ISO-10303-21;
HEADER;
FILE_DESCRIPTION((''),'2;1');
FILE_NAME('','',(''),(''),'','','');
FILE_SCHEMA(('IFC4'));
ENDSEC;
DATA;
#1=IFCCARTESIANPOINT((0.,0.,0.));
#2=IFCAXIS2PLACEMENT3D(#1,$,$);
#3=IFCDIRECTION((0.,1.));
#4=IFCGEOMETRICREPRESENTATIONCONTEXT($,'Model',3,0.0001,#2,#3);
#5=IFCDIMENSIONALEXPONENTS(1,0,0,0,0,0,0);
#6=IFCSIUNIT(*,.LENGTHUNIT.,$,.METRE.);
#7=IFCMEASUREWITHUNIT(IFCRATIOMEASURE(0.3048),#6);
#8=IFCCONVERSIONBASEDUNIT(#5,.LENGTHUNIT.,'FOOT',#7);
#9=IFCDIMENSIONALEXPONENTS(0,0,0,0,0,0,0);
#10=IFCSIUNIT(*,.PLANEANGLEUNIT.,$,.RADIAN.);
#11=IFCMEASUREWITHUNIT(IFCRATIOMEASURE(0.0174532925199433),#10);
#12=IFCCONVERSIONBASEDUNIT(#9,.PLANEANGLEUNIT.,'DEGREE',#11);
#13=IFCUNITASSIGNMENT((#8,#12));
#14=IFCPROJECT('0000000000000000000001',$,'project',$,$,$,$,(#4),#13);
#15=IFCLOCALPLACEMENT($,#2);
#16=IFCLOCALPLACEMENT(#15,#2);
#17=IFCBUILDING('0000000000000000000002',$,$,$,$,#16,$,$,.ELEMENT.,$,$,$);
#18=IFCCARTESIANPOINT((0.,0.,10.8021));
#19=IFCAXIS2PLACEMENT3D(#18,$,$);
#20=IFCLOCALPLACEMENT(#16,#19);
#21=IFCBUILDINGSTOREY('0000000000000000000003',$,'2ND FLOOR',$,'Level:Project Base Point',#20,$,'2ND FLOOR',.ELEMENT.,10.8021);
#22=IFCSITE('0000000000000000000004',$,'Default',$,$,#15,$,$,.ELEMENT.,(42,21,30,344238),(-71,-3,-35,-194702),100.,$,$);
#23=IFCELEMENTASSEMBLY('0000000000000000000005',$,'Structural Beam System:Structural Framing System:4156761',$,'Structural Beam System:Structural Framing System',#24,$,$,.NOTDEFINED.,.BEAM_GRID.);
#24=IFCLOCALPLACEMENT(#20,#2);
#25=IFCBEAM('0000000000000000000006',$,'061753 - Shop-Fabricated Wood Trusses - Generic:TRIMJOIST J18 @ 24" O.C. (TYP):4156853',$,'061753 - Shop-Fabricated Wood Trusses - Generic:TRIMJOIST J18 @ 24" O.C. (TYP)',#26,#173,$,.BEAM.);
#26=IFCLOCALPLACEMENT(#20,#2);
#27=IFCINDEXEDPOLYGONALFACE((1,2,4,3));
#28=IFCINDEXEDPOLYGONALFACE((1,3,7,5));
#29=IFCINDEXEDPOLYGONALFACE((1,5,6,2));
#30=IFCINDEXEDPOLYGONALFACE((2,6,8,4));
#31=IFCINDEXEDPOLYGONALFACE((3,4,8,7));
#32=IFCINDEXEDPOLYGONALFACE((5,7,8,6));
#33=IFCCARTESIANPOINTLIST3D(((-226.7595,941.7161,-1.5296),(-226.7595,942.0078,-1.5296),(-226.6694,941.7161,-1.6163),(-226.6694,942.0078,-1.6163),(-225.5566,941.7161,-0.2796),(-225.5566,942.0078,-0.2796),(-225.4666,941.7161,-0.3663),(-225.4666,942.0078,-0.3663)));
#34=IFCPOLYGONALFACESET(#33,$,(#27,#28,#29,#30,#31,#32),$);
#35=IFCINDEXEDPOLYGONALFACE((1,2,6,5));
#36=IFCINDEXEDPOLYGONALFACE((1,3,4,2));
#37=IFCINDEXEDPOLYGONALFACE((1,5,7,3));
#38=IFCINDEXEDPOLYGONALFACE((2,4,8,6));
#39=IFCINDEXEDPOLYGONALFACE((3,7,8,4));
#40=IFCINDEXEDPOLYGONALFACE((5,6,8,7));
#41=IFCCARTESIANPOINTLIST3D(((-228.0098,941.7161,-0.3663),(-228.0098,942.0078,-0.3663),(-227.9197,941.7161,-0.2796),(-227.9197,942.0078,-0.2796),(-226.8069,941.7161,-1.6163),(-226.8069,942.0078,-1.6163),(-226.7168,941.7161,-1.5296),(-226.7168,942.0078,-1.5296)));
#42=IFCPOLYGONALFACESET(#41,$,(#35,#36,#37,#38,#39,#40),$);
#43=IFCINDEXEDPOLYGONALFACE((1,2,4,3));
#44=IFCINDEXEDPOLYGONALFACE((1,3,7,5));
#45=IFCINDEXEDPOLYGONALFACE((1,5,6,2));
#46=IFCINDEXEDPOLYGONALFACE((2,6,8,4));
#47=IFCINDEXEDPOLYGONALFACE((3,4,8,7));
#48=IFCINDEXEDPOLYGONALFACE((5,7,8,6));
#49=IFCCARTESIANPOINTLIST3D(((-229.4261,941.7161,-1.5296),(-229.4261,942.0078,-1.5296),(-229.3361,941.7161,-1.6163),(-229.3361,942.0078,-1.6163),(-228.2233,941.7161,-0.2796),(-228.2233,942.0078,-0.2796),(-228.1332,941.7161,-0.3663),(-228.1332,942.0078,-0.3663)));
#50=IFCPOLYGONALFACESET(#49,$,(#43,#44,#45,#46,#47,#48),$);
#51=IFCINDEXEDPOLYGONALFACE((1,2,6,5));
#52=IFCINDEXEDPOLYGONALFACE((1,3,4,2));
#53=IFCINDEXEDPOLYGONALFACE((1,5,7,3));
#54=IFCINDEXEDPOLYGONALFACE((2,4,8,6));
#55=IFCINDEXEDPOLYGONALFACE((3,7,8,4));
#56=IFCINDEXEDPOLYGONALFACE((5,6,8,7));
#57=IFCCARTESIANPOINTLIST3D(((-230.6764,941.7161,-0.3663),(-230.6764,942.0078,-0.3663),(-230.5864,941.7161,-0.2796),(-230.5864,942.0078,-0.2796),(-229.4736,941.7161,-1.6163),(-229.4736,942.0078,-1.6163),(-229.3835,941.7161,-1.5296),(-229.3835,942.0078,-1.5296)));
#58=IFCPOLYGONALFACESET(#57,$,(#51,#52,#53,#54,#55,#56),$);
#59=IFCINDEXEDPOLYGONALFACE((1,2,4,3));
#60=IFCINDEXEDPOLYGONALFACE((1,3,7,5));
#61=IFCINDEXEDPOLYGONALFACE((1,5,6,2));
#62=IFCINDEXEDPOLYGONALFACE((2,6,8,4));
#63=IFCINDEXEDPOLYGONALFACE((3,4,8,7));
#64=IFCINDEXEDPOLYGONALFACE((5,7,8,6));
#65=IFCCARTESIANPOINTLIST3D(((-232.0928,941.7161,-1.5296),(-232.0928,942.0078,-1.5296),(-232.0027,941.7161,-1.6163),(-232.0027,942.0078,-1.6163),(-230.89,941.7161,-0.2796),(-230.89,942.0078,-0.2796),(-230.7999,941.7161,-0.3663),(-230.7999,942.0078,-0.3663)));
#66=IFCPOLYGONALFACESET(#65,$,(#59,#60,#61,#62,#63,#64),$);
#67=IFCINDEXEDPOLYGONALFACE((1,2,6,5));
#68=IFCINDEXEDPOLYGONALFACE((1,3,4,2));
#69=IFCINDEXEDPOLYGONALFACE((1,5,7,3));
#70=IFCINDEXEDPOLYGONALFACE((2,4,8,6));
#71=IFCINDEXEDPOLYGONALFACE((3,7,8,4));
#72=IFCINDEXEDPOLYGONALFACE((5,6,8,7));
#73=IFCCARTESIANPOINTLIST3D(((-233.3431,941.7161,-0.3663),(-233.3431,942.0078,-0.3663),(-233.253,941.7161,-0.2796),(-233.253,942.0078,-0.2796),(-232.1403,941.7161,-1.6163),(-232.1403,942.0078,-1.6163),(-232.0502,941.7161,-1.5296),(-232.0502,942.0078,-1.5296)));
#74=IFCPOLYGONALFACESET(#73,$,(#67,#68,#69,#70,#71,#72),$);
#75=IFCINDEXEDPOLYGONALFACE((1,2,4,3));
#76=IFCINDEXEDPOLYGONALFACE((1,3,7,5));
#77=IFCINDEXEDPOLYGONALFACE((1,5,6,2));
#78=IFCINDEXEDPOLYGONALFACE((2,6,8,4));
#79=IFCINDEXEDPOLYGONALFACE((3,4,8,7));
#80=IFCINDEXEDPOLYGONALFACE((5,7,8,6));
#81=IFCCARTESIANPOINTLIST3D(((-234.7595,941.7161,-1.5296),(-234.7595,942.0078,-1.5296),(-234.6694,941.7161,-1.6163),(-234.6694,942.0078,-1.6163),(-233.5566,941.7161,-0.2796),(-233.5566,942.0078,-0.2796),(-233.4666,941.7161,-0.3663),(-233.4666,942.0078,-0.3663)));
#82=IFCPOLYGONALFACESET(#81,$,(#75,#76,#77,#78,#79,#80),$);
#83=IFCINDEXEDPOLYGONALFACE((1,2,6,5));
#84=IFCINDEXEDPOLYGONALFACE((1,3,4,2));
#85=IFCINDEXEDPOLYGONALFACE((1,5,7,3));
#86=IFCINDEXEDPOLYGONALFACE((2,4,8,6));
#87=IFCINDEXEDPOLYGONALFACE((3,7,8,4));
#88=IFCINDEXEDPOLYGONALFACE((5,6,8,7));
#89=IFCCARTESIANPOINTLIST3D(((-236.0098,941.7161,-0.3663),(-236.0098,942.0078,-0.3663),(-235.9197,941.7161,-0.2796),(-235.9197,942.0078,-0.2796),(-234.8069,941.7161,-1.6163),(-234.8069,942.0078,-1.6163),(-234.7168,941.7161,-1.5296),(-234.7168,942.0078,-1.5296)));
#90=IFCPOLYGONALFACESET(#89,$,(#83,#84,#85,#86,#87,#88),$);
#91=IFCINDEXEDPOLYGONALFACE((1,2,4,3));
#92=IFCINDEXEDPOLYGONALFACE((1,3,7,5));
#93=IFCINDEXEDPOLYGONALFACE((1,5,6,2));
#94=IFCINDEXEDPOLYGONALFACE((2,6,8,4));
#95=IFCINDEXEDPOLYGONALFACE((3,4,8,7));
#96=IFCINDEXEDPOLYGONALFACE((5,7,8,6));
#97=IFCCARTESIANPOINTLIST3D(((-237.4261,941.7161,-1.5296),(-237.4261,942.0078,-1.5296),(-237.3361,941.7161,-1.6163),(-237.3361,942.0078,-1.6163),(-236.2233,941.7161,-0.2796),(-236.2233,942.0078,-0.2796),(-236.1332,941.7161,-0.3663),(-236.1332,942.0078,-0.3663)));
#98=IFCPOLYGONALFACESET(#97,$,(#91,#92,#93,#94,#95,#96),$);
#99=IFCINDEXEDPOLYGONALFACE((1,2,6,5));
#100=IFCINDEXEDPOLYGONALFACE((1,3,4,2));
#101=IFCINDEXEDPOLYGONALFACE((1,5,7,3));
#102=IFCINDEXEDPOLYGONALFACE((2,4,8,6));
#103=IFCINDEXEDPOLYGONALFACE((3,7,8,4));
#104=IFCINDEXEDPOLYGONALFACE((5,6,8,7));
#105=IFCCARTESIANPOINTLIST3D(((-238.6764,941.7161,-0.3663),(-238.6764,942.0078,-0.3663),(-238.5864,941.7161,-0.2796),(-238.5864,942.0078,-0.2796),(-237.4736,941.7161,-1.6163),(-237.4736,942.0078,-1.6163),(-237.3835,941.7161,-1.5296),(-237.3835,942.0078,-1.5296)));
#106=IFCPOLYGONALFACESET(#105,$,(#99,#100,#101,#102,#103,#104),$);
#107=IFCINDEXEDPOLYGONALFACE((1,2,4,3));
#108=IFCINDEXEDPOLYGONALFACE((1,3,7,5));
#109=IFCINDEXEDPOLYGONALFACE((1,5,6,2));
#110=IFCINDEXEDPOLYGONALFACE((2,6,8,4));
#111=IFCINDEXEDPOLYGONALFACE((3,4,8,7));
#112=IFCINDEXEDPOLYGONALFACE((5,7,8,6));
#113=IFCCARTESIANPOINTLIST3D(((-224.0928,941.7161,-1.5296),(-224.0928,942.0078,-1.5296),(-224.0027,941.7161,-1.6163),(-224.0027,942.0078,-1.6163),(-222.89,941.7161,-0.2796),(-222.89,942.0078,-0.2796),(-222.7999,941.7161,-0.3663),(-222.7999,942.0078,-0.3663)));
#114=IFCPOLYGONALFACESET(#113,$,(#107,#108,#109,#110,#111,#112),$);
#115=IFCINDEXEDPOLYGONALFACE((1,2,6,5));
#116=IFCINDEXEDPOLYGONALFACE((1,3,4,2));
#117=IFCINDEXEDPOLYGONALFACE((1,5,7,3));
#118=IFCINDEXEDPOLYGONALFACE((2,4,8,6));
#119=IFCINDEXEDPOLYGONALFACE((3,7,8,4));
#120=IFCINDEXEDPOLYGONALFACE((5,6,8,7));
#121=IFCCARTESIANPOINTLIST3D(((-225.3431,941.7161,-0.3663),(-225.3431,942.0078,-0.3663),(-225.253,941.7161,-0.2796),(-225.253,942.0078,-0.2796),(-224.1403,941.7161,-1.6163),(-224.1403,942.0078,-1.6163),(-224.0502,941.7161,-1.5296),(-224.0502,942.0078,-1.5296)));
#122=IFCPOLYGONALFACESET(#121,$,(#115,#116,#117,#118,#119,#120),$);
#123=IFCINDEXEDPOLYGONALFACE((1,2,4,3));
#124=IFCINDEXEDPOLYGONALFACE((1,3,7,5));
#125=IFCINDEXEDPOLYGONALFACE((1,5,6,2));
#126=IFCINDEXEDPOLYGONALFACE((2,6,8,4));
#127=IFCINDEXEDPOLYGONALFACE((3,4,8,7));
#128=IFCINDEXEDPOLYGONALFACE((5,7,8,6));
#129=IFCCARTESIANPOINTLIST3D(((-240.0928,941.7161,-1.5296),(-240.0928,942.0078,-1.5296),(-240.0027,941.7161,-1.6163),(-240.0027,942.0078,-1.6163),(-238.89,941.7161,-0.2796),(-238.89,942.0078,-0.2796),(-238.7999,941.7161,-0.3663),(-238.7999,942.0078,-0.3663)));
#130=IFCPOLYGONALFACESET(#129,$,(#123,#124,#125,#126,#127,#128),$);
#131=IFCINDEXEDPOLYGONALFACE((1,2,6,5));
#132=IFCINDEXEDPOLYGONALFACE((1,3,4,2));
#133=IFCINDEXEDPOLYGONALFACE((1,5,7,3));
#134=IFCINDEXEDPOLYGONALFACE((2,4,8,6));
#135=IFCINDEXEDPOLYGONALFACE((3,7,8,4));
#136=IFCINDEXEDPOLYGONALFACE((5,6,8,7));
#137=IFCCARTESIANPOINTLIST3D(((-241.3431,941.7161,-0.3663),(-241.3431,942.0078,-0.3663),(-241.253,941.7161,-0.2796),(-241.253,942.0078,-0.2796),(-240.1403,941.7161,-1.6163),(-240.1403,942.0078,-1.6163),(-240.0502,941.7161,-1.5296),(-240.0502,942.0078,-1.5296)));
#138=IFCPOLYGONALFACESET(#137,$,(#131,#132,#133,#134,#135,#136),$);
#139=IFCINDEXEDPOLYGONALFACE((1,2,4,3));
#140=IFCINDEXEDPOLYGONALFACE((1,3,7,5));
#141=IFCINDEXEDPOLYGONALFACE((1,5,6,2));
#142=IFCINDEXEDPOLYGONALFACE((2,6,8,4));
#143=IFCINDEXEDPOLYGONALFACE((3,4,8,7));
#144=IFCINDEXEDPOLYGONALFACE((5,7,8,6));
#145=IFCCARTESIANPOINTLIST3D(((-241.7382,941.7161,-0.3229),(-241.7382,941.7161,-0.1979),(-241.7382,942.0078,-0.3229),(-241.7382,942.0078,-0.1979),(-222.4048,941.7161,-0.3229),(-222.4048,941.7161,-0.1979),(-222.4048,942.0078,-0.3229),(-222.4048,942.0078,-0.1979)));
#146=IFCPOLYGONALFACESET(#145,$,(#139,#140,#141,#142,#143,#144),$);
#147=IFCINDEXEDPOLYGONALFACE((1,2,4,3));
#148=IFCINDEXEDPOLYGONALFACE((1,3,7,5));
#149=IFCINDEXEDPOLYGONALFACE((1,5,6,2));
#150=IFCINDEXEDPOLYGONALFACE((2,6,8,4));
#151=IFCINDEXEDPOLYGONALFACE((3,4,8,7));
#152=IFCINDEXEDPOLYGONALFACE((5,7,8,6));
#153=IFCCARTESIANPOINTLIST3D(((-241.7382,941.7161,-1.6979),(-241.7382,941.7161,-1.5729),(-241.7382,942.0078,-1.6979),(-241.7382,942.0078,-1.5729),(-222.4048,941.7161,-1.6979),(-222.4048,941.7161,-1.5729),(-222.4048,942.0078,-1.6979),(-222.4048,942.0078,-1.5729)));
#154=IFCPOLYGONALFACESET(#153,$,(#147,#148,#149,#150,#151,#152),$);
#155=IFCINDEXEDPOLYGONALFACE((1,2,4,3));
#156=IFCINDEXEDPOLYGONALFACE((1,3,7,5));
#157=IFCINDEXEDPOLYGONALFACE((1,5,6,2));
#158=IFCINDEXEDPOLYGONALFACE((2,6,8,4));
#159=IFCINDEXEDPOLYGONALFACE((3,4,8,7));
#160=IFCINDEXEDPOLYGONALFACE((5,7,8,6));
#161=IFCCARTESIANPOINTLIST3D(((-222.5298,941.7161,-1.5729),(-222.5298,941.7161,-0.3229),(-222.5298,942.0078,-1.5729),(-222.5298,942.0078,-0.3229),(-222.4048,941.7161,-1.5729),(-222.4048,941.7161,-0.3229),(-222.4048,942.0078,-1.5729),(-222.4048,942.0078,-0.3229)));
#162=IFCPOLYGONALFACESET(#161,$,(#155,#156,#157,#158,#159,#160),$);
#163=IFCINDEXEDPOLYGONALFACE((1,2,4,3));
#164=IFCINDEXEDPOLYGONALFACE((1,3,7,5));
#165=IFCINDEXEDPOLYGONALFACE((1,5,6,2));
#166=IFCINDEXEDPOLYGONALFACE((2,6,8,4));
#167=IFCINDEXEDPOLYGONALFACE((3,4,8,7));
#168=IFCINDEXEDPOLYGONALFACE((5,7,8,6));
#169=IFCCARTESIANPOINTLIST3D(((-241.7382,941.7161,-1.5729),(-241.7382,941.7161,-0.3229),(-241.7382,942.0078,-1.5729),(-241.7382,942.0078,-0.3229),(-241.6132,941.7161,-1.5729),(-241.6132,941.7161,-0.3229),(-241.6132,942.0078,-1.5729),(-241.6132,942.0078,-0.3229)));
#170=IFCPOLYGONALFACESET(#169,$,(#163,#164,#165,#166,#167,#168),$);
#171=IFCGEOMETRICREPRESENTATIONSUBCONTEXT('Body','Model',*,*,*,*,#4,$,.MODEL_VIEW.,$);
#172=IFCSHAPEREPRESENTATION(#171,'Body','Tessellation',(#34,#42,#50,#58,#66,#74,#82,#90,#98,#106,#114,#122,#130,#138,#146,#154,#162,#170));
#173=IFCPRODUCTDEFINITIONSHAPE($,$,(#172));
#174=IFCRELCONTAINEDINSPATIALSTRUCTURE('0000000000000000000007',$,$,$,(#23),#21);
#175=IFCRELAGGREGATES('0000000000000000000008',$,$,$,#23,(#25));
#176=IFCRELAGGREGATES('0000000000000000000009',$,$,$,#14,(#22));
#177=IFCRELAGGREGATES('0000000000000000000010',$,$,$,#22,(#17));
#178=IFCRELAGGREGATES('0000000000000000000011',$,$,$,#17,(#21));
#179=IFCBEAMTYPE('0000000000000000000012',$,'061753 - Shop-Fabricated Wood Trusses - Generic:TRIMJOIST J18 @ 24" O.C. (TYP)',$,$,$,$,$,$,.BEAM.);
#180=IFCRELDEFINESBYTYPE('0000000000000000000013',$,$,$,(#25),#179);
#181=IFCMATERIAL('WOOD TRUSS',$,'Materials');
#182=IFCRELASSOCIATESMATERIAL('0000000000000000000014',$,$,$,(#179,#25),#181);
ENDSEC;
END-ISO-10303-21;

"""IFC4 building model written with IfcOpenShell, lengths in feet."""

from ifc_helpers import new_model, entity, si_unit, converted_unit, direction, frame, frame_2d, origin, origin_2d_with_axis, place, context, subcontext, project, spatial, rectangle, extrude, source, transform, mapped, material, material_profile, profile_set, profile_usage, type_object, type_shapes, element, aggregate, save


model = new_model("IFC4")

# Units and contexts
model_context = context("Model", 3, precision=0.0001, world=origin(), true_north=direction((0.0, 1.0)))
body_context = subcontext(model_context, "Body", "Model", "MODEL_VIEW")
ifc_project = project(units=[converted_unit("LENGTHUNIT", "FOOT", entity("IfcRatioMeasure", 0.3048), si_unit("LENGTHUNIT", "METRE"), dimensions=[1, 0, 0, 0, 0, 0, 0]), converted_unit("PLANEANGLEUNIT", "DEGREE", entity("IfcRatioMeasure", 0.0174532925199433), si_unit("PLANEANGLEUNIT", "RADIAN"), dimensions=[0, 0, 0, 0, 0, 0, 0])], contexts=[model_context])

# Site, building, storey
site_placement = place(None, origin())
site = spatial("IfcSite", under=ifc_project, at=site_placement, Name="Default", CompositionType="ELEMENT", RefLatitude=(42, 21, 30, 344238), RefLongitude=(-71, -3, -35, -194702), RefElevation=100.0)
building_placement = place(site_placement, origin())
building = spatial("IfcBuilding", under=site, at=building_placement, CompositionType="ELEMENT")
storey_placement = place(building_placement, frame((0.0, 0.0, 10.8021)))
storey = spatial("IfcBuildingStorey", under=building, at=storey_placement, Name="2ND FLOOR", ObjectType="Level:Project Base Point", LongName="2ND FLOOR", CompositionType="ELEMENT", Elevation=10.8021)

# Element assembly, beam
assembly_1_placement = place(storey_placement, origin())
assembly_1 = element("IfcElementAssembly", 1, at=assembly_1_placement, inside=storey, Name="Structural Beam System:Structural Framing System:4156761", ObjectType="Structural Beam System:Structural Framing System", AssemblyPlace="NOTDEFINED", PredefinedType="BEAM_GRID")
ifc_material_1 = material(Name="WOOD TRUSS", Category="Materials")
ifc_material_profile_1 = material_profile(ifc_material_1, rectangle(XDim=1.7347, YDim=0.125, at=frame_2d((0.0, 0.0), x_axis=(1.0, 0.0))), Name="TRIMJOIST J18 @ 24\" O.C. (TYP)")
ifc_material_profile_2 = material_profile(ifc_material_1, rectangle(XDim=1.7347, YDim=0.125, at=frame_2d((0.0, 0.0), x_axis=(1.0, 0.0))), Name="TRIMJOIST J18 @ 24\" O.C. (TYP)")
ifc_material_profile_3 = material_profile(ifc_material_1, rectangle(XDim=1.7347, YDim=0.125, at=frame_2d((0.0, 0.0), x_axis=(1.0, 0.0))), Name="TRIMJOIST J18 @ 24\" O.C. (TYP)")
ifc_material_profile_4 = material_profile(ifc_material_1, rectangle(XDim=1.7347, YDim=0.125, at=frame_2d((0.0, 0.0), x_axis=(1.0, 0.0))), Name="TRIMJOIST J18 @ 24\" O.C. (TYP)")
ifc_material_profile_5 = material_profile(ifc_material_1, rectangle(XDim=1.7347, YDim=0.125, at=frame_2d((0.0, 0.0), x_axis=(1.0, 0.0))), Name="TRIMJOIST J18 @ 24\" O.C. (TYP)")
ifc_material_profile_6 = material_profile(ifc_material_1, rectangle(XDim=1.7347, YDim=0.125, at=frame_2d((0.0, 0.0), x_axis=(1.0, 0.0))), Name="TRIMJOIST J18 @ 24\" O.C. (TYP)")
ifc_material_profile_7 = material_profile(ifc_material_1, rectangle(XDim=1.7347, YDim=0.125, at=frame_2d((0.0, 0.0), x_axis=(1.0, 0.0))), Name="TRIMJOIST J18 @ 24\" O.C. (TYP)")
ifc_material_profile_8 = material_profile(ifc_material_1, rectangle(XDim=1.7347, YDim=0.125, at=frame_2d((0.0, 0.0), x_axis=(1.0, 0.0))), Name="TRIMJOIST J18 @ 24\" O.C. (TYP)")
ifc_material_profile_9 = material_profile(ifc_material_1, rectangle(XDim=1.7347, YDim=0.125, at=frame_2d((0.0, 0.0), x_axis=(1.0, 0.0))), Name="TRIMJOIST J18 @ 24\" O.C. (TYP)")
ifc_material_profile_10 = material_profile(ifc_material_1, rectangle(XDim=1.7347, YDim=0.125, at=origin_2d_with_axis()), Name="TRIMJOIST J18 @ 24\" O.C. (TYP)")
ifc_material_profile_11 = material_profile(ifc_material_1, rectangle(XDim=0.125, YDim=0.2917, at=origin_2d_with_axis()), Name="TRIMJOIST J18 @ 24\" O.C. (TYP)")
ifc_material_profile_12 = material_profile(ifc_material_1, rectangle(XDim=0.125, YDim=0.2917, at=origin_2d_with_axis()), Name="TRIMJOIST J18 @ 24\" O.C. (TYP)")
ifc_material_profile_13 = material_profile(ifc_material_1, rectangle(XDim=1.25, YDim=0.2917, at=origin_2d_with_axis()), Name="TRIMJOIST J18 @ 24\" O.C. (TYP)")
ifc_material_profile_14 = material_profile(ifc_material_1, rectangle(XDim=1.25, YDim=0.2917, at=origin_2d_with_axis()), Name="TRIMJOIST J18 @ 24\" O.C. (TYP)")
ifc_profile_set_1 = profile_set([ifc_material_profile_1, ifc_material_profile_2, ifc_material_profile_3, ifc_material_profile_4, ifc_material_profile_5, ifc_material_profile_6, ifc_material_profile_7, ifc_material_profile_8, ifc_material_profile_9, ifc_material_profile_10, ifc_material_profile_11, ifc_material_profile_12, ifc_material_profile_13, ifc_material_profile_14], Name="TRIMJOIST J18 @ 24\" O.C. (TYP)")
beam_type_1 = type_object("IfcBeamType", Name="061753 - Shop-Fabricated Wood Trusses - Generic:TRIMJOIST J18 @ 24\" O.C. (TYP)", PredefinedType="BEAM", material=ifc_profile_set_1)
shared_shape_1 = source(origin(), body_context, "Body", "SweptSolid", [
    extrude(rectangle(XDim=1.7347, YDim=0.125, at=frame_2d((0.0, 0.0), x_axis=(1.0, 0.0))), frame((5.9585, -0.1458, 0.0), z_axis=(0.0, 1.0, 0.0), x_axis=(0.693383, 0.0, 0.720569)), (0.0, 0.0, 1.0), 0.2917),
    extrude(rectangle(XDim=1.7347, YDim=0.125, at=origin_2d_with_axis()), frame((4.7082, -0.1458, 0.0), z_axis=(0.0, 1.0, 0.0), x_axis=(0.693383, 0.0, -0.720569)), (0.0, 0.0, 1.0), 0.2917),
    extrude(rectangle(XDim=1.7347, YDim=0.125, at=frame_2d((0.0, 0.0), x_axis=(1.0, 0.0))), frame((3.2918, -0.1458, 0.0), z_axis=(0.0, 1.0, 0.0), x_axis=(0.693383, 0.0, 0.720569)), (0.0, 0.0, 1.0), 0.2917),
    extrude(rectangle(XDim=1.7347, YDim=0.125, at=frame_2d((0.0, 0.0), x_axis=(1.0, 0.0))), frame((2.0415, -0.1458, 0.0), z_axis=(0.0, 1.0, 0.0), x_axis=(0.693383, 0.0, -0.720569)), (0.0, 0.0, 1.0), 0.2917),
    extrude(rectangle(XDim=1.7347, YDim=0.125, at=frame_2d((0.0, 0.0), x_axis=(1.0, 0.0))), frame((0.6251, -0.1458, 0.0), z_axis=(0.0, 1.0, 0.0), x_axis=(0.693383, 0.0, 0.720569)), (0.0, 0.0, 1.0), 0.2917),
    extrude(rectangle(XDim=1.7347, YDim=0.125, at=frame_2d((0.0, 0.0), x_axis=(1.0, 0.0))), frame((-0.6251, -0.1458, 0.0), z_axis=(0.0, 1.0, 0.0), x_axis=(0.693383, 0.0, -0.720569)), (0.0, 0.0, 1.0), 0.2917),
    extrude(rectangle(XDim=1.7347, YDim=0.125, at=frame_2d((0.0, 0.0), x_axis=(1.0, 0.0))), frame((-2.0415, -0.1458, 0.0), z_axis=(0.0, 1.0, 0.0), x_axis=(0.693383, 0.0, 0.720569)), (0.0, 0.0, 1.0), 0.2917),
    extrude(rectangle(XDim=1.7347, YDim=0.125, at=origin_2d_with_axis()), frame((-3.2918, -0.1458, 0.0), z_axis=(0.0, 1.0, 0.0), x_axis=(0.693383, 0.0, -0.720569)), (0.0, 0.0, 1.0), 0.2917),
    extrude(rectangle(XDim=1.7347, YDim=0.125, at=frame_2d((0.0, 0.0), x_axis=(1.0, 0.0))), frame((-4.7082, -0.1458, 0.0), z_axis=(0.0, 1.0, 0.0), x_axis=(0.693383, 0.0, 0.720569)), (0.0, 0.0, 1.0), 0.2917),
    extrude(rectangle(XDim=1.7347, YDim=0.125, at=frame_2d((0.0, 0.0), x_axis=(1.0, 0.0))), frame((-5.9585, -0.1458, 0.0), z_axis=(0.0, 1.0, 0.0), x_axis=(0.693383, 0.0, -0.720569)), (0.0, 0.0, 1.0), 0.2917),
    extrude(rectangle(XDim=1.7347, YDim=0.125, at=frame_2d((0.0, 0.0), x_axis=(1.0, 0.0))), frame((8.6251, -0.1458, 0.0), z_axis=(0.0, 1.0, 0.0), x_axis=(0.693383, 0.0, 0.720569)), (0.0, 0.0, 1.0), 0.2917),
    extrude(rectangle(XDim=1.7347, YDim=0.125, at=origin_2d_with_axis()), frame((7.3749, -0.1458, 0.0), z_axis=(0.0, 1.0, 0.0), x_axis=(0.693383, 0.0, -0.720569)), (0.0, 0.0, 1.0), 0.2917),
    extrude(rectangle(XDim=1.7347, YDim=0.125, at=frame_2d((0.0, 0.0), x_axis=(1.0, 0.0))), frame((-7.3749, -0.1458, 0.0), z_axis=(0.0, 1.0, 0.0), x_axis=(0.693383, 0.0, 0.720569)), (0.0, 0.0, 1.0), 0.2917),
    extrude(rectangle(XDim=1.7347, YDim=0.125, at=origin_2d_with_axis()), frame((-8.6251, -0.1458, 0.0), z_axis=(0.0, 1.0, 0.0), x_axis=(0.693383, 0.0, -0.720569)), (0.0, 0.0, 1.0), 0.2917),
    extrude(rectangle(XDim=0.125, YDim=0.2917, at=origin_2d_with_axis()), frame((-9.6667, 0.0, 0.6875), z_axis=(1.0, 0.0, 0.0), x_axis=(0.0, 0.0, -1.0)), (0.0, 0.0, 1.0), 19.3333),
    extrude(rectangle(XDim=0.125, YDim=0.2917, at=origin_2d_with_axis()), frame((-9.6667, 0.0, -0.6875), z_axis=(1.0, 0.0, 0.0), x_axis=(0.0, 0.0, -1.0)), (0.0, 0.0, 1.0), 19.3333),
    extrude(rectangle(XDim=1.25, YDim=0.2917, at=origin_2d_with_axis()), frame((9.5417, 0.0, 0.0), z_axis=(1.0, 0.0, 0.0), x_axis=(0.0, 0.0, -1.0)), (0.0, 0.0, 1.0), 0.125),
    extrude(rectangle(XDim=1.25, YDim=0.2917, at=origin_2d_with_axis()), frame((-9.6667, 0.0, 0.0), z_axis=(1.0, 0.0, 0.0), x_axis=(0.0, 0.0, -1.0)), (0.0, 0.0, 1.0), 0.125),
])
type_shapes(beam_type_1, [shared_shape_1])
ifc_profile_usage_1 = profile_usage(ifc_profile_set_1, cardinal=8)
beam_1_placement = place(assembly_1_placement, frame((-232.0715, 941.8619, -0.9479)))
beam_1 = element("IfcBeam", 2, at=beam_1_placement, type_object=beam_type_1, material=ifc_profile_usage_1, Name="061753 - Shop-Fabricated Wood Trusses - Generic:TRIMJOIST J18 @ 24\" O.C. (TYP):4156853", ObjectType="061753 - Shop-Fabricated Wood Trusses - Generic:TRIMJOIST J18 @ 24\" O.C. (TYP)", PredefinedType="BEAM", context=body_context, shape_type="MappedRepresentation", body=[
    mapped(shared_shape_1, transform((0.0, 0.0, 0.0), scale=1.0)),
])
aggregate(assembly_1, [beam_1])

save(model, "model.ifc")
